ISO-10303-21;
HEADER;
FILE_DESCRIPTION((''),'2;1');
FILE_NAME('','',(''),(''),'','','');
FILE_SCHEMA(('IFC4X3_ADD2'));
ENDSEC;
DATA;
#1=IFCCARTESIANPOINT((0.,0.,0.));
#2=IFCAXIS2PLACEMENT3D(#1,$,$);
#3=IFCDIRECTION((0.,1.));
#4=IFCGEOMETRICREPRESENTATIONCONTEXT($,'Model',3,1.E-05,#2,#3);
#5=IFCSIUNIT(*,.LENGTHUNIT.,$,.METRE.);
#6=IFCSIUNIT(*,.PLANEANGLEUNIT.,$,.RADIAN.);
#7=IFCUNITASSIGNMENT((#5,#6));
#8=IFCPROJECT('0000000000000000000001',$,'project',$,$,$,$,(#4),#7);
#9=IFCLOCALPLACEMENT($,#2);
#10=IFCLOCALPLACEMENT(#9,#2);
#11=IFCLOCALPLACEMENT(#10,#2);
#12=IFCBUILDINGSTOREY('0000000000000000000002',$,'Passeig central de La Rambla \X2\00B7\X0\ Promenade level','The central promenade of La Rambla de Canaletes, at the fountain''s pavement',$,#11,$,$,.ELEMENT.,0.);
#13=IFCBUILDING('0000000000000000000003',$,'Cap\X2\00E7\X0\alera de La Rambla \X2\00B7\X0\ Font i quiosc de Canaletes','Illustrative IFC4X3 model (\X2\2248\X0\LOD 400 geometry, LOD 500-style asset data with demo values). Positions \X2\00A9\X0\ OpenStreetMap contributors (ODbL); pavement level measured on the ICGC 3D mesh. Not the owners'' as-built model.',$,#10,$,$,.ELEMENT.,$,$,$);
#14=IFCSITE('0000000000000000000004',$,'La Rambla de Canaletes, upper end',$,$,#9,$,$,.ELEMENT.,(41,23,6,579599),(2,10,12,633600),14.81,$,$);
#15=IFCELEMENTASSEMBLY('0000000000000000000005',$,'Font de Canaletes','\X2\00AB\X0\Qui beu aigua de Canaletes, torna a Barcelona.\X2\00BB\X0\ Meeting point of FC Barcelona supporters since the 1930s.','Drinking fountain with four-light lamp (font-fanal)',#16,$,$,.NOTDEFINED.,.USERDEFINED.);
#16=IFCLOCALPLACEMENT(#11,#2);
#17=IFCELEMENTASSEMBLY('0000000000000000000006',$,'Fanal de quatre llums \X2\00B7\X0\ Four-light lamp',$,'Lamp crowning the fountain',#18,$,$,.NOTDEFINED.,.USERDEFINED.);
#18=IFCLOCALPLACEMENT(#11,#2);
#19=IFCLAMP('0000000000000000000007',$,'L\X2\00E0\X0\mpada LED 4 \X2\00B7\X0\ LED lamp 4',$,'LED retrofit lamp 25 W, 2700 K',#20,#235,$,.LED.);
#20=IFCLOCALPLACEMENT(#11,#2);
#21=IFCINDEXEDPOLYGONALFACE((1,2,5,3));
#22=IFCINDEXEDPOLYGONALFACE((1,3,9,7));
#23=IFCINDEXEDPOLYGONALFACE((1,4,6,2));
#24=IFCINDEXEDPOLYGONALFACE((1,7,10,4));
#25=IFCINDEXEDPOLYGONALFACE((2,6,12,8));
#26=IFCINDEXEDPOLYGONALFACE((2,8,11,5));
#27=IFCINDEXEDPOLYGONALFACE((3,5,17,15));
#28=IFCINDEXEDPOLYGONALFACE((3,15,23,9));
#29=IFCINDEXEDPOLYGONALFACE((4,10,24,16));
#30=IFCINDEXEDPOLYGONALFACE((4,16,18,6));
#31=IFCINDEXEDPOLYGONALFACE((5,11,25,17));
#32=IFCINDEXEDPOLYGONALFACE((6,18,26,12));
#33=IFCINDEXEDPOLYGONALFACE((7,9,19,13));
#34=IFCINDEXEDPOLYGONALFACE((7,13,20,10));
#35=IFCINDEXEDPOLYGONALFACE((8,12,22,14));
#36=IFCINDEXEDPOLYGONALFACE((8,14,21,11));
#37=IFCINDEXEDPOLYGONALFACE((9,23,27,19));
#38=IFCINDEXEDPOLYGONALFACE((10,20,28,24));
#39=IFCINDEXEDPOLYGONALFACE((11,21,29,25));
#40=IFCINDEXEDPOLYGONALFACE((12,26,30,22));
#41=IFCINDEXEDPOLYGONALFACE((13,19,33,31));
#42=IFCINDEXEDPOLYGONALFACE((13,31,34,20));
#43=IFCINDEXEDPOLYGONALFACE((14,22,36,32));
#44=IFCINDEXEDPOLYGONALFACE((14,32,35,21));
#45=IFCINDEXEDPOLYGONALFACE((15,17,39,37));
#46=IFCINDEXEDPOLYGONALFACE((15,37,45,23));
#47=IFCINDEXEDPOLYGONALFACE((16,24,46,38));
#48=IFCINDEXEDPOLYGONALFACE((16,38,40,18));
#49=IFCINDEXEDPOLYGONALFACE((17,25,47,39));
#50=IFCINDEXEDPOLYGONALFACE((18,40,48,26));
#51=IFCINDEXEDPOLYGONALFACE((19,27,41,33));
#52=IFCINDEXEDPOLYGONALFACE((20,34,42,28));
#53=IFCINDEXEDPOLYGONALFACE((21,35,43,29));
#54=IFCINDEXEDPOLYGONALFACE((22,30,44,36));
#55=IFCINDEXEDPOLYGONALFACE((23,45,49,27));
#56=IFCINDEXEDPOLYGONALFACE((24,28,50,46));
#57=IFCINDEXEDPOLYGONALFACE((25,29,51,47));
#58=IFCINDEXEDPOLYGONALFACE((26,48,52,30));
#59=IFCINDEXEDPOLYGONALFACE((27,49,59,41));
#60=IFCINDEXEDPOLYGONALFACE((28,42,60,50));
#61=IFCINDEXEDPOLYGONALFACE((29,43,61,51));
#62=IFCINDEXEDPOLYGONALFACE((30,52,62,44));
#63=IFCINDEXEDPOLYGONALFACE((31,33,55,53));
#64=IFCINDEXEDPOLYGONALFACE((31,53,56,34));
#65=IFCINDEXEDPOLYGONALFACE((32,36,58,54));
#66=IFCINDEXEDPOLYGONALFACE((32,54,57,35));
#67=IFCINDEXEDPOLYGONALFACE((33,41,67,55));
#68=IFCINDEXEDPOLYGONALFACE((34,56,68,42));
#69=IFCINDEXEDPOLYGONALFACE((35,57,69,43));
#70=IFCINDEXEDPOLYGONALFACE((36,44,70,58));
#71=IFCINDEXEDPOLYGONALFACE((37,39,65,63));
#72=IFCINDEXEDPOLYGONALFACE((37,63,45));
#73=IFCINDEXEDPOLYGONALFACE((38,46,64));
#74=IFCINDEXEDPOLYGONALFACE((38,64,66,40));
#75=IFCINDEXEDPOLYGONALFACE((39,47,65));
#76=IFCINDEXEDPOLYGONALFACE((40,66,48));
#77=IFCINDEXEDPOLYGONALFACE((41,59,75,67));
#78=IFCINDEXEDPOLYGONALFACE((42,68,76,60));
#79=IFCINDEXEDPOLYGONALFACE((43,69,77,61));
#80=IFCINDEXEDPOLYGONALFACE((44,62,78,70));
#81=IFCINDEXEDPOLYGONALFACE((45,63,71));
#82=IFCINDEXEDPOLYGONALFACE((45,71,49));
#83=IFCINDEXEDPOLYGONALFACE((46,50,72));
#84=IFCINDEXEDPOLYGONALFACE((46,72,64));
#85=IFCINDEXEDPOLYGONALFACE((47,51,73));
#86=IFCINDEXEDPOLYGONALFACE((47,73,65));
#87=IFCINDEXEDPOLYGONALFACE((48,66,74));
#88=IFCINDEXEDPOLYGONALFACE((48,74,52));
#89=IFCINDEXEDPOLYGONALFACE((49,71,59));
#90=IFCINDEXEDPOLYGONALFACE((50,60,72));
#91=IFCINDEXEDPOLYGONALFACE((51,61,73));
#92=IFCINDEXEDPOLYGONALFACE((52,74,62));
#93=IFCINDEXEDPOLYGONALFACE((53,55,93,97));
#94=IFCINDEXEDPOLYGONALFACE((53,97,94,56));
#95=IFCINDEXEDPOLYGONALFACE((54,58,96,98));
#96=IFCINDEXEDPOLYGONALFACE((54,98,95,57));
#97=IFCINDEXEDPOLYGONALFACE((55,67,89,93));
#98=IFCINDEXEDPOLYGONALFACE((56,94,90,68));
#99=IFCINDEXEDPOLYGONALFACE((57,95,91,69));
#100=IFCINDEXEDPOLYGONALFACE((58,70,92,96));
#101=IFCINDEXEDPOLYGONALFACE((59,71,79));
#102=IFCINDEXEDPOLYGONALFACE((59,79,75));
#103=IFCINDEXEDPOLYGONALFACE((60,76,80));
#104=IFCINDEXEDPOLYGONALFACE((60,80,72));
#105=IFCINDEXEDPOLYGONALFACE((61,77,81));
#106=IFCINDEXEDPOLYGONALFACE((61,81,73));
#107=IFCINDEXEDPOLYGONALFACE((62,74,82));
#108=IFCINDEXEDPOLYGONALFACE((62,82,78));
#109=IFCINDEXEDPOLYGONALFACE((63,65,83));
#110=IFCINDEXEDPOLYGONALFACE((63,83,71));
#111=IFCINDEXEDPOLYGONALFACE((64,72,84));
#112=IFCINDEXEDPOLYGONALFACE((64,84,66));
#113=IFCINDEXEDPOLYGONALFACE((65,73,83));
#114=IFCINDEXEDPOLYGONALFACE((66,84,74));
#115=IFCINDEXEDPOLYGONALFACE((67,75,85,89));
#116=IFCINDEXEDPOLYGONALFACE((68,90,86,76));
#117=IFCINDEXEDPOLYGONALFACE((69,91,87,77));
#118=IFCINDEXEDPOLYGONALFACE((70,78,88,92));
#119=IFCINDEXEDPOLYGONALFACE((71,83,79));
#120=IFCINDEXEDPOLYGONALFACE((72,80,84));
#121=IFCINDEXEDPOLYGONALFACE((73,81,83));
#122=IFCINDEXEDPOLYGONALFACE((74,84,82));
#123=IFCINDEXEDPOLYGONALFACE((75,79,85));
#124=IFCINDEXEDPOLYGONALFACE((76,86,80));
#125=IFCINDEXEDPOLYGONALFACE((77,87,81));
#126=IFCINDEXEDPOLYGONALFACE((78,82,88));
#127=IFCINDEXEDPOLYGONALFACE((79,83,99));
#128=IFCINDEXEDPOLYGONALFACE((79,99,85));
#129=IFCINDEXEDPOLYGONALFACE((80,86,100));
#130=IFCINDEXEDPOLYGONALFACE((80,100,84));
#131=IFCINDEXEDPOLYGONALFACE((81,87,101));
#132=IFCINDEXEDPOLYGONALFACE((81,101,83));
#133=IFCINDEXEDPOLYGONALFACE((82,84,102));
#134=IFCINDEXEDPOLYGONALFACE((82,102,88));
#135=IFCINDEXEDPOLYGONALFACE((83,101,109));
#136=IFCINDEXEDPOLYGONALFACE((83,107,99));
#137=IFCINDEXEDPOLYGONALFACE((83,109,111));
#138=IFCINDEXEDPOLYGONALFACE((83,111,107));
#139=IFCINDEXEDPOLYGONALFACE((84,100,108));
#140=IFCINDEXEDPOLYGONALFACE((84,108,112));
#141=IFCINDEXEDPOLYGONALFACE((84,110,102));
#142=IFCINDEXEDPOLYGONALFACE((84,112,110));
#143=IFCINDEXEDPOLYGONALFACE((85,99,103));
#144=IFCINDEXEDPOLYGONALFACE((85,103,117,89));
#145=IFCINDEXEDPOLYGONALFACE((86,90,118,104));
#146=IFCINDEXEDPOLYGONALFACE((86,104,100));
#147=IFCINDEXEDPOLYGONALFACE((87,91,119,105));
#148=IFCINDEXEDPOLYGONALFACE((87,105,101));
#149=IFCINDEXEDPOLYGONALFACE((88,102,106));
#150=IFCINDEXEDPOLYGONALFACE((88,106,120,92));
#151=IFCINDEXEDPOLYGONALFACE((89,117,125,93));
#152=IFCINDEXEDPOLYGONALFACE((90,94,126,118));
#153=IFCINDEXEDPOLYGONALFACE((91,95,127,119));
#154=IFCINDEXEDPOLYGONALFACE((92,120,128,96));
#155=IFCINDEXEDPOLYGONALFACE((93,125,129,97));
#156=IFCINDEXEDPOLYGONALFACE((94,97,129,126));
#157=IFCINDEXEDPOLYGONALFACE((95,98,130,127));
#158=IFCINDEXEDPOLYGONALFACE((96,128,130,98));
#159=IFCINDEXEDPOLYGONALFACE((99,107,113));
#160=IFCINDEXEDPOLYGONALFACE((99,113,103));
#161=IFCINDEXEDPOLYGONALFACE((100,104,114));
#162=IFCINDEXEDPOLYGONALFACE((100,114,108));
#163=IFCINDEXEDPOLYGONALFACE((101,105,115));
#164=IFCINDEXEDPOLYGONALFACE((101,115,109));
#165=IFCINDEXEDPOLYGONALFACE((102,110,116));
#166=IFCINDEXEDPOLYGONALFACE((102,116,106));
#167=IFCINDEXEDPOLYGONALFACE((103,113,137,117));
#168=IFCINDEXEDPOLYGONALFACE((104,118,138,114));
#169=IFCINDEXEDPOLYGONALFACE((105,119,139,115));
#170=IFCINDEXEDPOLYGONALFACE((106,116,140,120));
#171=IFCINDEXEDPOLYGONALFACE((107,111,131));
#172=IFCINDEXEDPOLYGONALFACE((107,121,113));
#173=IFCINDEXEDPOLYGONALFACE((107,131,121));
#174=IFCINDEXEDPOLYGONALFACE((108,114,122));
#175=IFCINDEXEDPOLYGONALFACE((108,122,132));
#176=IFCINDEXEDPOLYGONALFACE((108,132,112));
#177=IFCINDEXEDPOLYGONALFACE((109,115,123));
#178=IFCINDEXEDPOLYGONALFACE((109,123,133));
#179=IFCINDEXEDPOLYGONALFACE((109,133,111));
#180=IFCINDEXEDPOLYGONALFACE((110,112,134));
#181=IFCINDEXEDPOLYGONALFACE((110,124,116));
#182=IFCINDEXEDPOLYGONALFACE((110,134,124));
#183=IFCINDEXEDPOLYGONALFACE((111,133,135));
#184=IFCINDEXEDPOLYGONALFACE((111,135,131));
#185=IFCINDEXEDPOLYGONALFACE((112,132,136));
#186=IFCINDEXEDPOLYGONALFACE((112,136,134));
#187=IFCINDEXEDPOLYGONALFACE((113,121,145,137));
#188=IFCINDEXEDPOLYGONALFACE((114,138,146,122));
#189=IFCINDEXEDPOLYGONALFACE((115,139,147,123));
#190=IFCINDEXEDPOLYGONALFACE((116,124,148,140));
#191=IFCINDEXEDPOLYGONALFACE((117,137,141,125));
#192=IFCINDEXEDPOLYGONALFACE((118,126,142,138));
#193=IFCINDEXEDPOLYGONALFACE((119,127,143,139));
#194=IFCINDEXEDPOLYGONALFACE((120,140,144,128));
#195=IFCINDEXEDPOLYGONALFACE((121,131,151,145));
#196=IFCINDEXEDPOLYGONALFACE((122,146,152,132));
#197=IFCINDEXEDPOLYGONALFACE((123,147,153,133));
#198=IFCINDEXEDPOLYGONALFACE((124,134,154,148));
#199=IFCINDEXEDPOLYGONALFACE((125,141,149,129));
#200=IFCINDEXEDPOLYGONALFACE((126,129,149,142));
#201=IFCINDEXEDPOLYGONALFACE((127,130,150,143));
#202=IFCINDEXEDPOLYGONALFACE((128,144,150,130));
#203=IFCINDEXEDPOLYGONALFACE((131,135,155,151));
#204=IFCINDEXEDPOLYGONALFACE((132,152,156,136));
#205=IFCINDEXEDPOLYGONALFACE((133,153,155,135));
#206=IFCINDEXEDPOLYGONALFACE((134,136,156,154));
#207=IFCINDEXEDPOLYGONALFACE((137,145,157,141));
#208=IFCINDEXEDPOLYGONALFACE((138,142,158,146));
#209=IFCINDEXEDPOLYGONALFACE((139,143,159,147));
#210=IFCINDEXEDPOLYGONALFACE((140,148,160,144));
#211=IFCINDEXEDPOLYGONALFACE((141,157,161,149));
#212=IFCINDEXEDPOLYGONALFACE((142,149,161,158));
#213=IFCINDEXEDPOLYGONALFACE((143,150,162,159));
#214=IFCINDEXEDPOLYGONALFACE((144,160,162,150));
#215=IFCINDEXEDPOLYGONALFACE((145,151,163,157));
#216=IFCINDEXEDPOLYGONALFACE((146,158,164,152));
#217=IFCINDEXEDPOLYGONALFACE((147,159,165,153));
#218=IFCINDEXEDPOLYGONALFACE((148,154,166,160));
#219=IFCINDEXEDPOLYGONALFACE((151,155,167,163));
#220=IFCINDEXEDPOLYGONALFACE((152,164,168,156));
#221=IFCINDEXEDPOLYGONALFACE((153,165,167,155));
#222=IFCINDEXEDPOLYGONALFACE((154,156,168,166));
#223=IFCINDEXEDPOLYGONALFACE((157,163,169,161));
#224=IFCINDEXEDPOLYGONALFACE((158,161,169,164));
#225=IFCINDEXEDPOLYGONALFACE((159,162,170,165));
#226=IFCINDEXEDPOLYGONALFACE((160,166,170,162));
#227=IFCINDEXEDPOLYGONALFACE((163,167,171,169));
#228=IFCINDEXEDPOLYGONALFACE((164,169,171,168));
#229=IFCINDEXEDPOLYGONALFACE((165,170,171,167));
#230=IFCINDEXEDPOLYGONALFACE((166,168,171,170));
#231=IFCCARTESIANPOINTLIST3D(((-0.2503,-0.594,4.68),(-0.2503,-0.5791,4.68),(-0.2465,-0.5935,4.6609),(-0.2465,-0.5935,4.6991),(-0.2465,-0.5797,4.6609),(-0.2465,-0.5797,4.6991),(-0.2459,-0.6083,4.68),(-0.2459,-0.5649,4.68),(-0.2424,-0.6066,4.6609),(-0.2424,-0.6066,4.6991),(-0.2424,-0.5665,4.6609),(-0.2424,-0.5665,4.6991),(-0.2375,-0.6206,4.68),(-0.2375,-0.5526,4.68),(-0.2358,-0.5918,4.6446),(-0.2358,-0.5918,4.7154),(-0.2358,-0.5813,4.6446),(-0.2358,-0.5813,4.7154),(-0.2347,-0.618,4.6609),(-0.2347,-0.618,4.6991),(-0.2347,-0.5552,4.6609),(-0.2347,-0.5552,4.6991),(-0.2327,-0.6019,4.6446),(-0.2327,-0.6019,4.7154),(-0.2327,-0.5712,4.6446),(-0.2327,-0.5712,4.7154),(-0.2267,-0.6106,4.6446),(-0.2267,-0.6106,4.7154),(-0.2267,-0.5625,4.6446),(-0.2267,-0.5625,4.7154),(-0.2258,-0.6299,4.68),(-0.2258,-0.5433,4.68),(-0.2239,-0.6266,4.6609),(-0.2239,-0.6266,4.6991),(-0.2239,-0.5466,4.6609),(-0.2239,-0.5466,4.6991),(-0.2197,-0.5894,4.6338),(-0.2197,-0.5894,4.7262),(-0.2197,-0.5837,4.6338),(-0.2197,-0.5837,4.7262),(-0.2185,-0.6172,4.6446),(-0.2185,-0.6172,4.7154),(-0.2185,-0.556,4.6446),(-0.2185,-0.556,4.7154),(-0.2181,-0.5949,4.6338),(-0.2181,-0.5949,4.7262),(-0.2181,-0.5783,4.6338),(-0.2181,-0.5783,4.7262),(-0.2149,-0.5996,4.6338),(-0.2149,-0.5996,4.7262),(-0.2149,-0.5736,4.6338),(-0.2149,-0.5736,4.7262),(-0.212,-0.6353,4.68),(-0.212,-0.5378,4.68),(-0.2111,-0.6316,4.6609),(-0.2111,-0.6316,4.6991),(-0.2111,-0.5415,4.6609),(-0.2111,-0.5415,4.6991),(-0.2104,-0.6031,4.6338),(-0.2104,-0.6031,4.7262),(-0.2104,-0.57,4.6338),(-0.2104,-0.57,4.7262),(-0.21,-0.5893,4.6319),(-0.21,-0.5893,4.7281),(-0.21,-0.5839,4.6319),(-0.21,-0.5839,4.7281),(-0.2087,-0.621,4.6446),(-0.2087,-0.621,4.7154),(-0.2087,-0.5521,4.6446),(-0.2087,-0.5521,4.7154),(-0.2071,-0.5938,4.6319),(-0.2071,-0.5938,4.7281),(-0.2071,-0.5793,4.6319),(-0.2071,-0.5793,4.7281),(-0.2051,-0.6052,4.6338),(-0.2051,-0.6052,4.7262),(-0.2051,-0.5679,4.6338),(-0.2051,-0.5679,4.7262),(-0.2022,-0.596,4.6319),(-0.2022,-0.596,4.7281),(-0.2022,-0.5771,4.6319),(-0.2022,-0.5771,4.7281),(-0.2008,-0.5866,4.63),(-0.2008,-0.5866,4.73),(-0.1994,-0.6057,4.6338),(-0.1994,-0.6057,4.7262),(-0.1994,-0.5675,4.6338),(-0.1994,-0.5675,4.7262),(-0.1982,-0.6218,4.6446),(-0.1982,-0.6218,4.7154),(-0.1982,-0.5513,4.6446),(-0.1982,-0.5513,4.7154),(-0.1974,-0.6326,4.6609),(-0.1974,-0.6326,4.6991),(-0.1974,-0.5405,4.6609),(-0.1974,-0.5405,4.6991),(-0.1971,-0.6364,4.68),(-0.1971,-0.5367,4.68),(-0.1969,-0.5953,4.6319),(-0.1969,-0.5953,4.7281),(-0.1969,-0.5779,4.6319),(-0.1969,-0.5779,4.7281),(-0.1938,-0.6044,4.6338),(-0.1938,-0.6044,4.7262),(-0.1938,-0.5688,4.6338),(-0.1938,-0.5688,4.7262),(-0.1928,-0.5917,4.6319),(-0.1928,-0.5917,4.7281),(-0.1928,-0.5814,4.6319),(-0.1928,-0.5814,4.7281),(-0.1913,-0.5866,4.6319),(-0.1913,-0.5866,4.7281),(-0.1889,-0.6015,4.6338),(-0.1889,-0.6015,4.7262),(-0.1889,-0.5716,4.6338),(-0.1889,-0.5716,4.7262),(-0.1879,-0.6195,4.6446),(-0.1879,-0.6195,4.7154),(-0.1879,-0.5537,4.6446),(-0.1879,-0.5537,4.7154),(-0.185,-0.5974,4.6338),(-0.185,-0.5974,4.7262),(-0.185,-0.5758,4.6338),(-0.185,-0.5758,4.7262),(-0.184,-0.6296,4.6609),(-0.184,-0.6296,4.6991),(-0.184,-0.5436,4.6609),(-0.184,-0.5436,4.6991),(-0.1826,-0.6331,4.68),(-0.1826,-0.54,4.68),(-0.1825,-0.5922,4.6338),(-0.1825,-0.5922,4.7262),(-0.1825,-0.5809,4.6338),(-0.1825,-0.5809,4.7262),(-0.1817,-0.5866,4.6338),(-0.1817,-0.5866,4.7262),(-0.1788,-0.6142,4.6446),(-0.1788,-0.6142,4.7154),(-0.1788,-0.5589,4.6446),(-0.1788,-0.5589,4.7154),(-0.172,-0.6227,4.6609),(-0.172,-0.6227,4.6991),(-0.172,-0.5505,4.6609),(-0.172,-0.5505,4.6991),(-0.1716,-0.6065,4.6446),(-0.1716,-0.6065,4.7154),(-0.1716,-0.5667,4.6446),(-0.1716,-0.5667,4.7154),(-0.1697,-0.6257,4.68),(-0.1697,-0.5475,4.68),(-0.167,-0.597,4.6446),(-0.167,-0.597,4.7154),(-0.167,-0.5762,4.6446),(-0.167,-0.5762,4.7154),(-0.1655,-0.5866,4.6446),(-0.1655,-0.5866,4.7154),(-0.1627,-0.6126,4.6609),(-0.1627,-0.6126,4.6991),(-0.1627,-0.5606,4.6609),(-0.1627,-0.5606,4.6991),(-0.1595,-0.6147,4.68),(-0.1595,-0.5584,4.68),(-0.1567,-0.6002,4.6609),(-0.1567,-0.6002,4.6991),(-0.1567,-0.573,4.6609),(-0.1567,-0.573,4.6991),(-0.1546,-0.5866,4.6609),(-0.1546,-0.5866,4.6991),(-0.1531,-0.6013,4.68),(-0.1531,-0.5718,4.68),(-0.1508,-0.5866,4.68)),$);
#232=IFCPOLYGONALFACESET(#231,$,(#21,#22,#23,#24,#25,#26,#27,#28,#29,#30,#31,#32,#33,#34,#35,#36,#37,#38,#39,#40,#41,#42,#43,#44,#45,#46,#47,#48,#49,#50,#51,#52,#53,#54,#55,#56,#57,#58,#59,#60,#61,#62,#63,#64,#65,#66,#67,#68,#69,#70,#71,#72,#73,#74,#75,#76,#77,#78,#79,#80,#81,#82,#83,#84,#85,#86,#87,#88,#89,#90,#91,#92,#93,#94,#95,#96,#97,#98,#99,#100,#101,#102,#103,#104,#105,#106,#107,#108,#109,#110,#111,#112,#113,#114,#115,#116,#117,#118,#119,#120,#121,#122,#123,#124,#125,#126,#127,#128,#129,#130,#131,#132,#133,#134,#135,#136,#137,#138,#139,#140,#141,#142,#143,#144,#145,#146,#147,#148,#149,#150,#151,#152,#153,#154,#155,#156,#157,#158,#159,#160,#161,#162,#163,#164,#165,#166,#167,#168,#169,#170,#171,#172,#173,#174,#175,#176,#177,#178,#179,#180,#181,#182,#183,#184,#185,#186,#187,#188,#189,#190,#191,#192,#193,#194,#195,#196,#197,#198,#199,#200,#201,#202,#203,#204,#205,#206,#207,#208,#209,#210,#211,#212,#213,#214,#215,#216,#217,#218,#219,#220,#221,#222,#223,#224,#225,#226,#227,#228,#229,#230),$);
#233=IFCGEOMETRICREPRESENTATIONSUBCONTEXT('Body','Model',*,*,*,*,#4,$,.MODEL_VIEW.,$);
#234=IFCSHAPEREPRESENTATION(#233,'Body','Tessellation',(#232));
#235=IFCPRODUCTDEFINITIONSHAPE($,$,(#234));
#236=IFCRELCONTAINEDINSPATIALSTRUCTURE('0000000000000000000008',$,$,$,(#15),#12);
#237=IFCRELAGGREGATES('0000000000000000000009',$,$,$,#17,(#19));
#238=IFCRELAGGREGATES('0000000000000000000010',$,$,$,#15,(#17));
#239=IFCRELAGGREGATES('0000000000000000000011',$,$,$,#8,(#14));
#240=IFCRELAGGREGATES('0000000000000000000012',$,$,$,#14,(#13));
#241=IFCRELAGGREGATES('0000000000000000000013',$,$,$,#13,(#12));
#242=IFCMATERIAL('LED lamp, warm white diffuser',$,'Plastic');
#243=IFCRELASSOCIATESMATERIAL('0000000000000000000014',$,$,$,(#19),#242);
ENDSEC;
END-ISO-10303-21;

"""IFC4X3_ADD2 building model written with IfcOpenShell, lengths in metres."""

from ifc_helpers import new_model, entity, si_unit, direction, origin, place, context, subcontext, project, spatial, material, element, aggregate, save


model = new_model("IFC4X3_ADD2")

# Units and contexts
model_context = context("Model", 3, precision=1e-05, world=origin(), true_north=direction((0.0, 1.0)))
body_context = subcontext(model_context, "Body", "Model", "MODEL_VIEW")
ifc_project = project(units=[si_unit("LENGTHUNIT", "METRE"), si_unit("PLANEANGLEUNIT", "RADIAN")], contexts=[model_context])

# Site, building, storey
site_placement = place(None, origin())
site = spatial("IfcSite", under=ifc_project, at=site_placement, Name="La Rambla de Canaletes, upper end", CompositionType="ELEMENT", RefLatitude=(41, 23, 6, 579599), RefLongitude=(2, 10, 12, 633600), RefElevation=14.81)
building_placement = place(site_placement, origin())
building = spatial("IfcBuilding", under=site, at=building_placement, Name="Capçalera de La Rambla · Font i quiosc de Canaletes", Description="Illustrative IFC4X3 model (≈LOD 400 geometry, LOD 500-style asset data with demo values). Positions © OpenStreetMap contributors (ODbL); pavement level measured on the ICGC 3D mesh. Not the owners' as-built model.", CompositionType="ELEMENT")
storey_placement = place(building_placement, origin())
storey = spatial("IfcBuildingStorey", under=building, at=storey_placement, Name="Passeig central de La Rambla · Promenade level", Description="The central promenade of La Rambla de Canaletes, at the fountain's pavement", CompositionType="ELEMENT", Elevation=0.0)

# Element assemblies, lamp
assembly_1_placement = place(building_placement, origin())
assembly_1 = element("IfcElementAssembly", 1, at=assembly_1_placement, inside=storey, Name="Font de Canaletes", Description="«Qui beu aigua de Canaletes, torna a Barcelona.» Meeting point of FC Barcelona supporters since the 1930s.", ObjectType="Drinking fountain with four-light lamp (font-fanal)", AssemblyPlace="NOTDEFINED", PredefinedType="USERDEFINED")
assembly_2_placement = place(building_placement, origin())
assembly_2 = element("IfcElementAssembly", 2, at=assembly_2_placement, Name="Fanal de quatre llums · Four-light lamp", ObjectType="Lamp crowning the fountain", AssemblyPlace="NOTDEFINED", PredefinedType="USERDEFINED")
ifc_material_1 = material(Name="LED lamp, warm white diffuser", Category="Plastic")
lamp_1_placement = place(building_placement, origin())
lamp_1 = element("IfcLamp", 3, at=lamp_1_placement, material=ifc_material_1, Name="Làmpada LED 4 · LED lamp 4", ObjectType="LED retrofit lamp 25 W, 2700 K", PredefinedType="LED", context=body_context, shape_type="SweptSolid", body=[
    entity("IfcRevolvedAreaSolid", entity("IfcArbitraryClosedProfileDef", "AREA", None, entity("IfcPolyline", [entity("IfcCartesianPoint", [0.0, -0.05]), entity("IfcCartesianPoint", [0.0191, -0.0462]), entity("IfcCartesianPoint", [0.0354, -0.0354]), entity("IfcCartesianPoint", [0.0462, -0.0191]), entity("IfcCartesianPoint", [0.05, 0.0]), entity("IfcCartesianPoint", [0.0462, 0.0191]), entity("IfcCartesianPoint", [0.0354, 0.0354]), entity("IfcCartesianPoint", [0.0191, 0.0462]), entity("IfcCartesianPoint", [0.0, 0.05]), entity("IfcCartesianPoint", [0.0, -0.05])])), entity("IfcAxis2Placement3D", entity("IfcCartesianPoint", [-0.2008, -0.5866, 4.68]), entity("IfcDirection", [0.0, -1.0, 0.0]), entity("IfcDirection", [1.0, 0.0, 0.0])), entity("IfcAxis1Placement", entity("IfcCartesianPoint", [0.0, 0.0, 0.0]), entity("IfcDirection", [0.0, 1.0, 0.0])), 6.283185),
])
aggregate(assembly_2, [lamp_1])
aggregate(assembly_1, [assembly_2])

save(model, "model.ifc")
